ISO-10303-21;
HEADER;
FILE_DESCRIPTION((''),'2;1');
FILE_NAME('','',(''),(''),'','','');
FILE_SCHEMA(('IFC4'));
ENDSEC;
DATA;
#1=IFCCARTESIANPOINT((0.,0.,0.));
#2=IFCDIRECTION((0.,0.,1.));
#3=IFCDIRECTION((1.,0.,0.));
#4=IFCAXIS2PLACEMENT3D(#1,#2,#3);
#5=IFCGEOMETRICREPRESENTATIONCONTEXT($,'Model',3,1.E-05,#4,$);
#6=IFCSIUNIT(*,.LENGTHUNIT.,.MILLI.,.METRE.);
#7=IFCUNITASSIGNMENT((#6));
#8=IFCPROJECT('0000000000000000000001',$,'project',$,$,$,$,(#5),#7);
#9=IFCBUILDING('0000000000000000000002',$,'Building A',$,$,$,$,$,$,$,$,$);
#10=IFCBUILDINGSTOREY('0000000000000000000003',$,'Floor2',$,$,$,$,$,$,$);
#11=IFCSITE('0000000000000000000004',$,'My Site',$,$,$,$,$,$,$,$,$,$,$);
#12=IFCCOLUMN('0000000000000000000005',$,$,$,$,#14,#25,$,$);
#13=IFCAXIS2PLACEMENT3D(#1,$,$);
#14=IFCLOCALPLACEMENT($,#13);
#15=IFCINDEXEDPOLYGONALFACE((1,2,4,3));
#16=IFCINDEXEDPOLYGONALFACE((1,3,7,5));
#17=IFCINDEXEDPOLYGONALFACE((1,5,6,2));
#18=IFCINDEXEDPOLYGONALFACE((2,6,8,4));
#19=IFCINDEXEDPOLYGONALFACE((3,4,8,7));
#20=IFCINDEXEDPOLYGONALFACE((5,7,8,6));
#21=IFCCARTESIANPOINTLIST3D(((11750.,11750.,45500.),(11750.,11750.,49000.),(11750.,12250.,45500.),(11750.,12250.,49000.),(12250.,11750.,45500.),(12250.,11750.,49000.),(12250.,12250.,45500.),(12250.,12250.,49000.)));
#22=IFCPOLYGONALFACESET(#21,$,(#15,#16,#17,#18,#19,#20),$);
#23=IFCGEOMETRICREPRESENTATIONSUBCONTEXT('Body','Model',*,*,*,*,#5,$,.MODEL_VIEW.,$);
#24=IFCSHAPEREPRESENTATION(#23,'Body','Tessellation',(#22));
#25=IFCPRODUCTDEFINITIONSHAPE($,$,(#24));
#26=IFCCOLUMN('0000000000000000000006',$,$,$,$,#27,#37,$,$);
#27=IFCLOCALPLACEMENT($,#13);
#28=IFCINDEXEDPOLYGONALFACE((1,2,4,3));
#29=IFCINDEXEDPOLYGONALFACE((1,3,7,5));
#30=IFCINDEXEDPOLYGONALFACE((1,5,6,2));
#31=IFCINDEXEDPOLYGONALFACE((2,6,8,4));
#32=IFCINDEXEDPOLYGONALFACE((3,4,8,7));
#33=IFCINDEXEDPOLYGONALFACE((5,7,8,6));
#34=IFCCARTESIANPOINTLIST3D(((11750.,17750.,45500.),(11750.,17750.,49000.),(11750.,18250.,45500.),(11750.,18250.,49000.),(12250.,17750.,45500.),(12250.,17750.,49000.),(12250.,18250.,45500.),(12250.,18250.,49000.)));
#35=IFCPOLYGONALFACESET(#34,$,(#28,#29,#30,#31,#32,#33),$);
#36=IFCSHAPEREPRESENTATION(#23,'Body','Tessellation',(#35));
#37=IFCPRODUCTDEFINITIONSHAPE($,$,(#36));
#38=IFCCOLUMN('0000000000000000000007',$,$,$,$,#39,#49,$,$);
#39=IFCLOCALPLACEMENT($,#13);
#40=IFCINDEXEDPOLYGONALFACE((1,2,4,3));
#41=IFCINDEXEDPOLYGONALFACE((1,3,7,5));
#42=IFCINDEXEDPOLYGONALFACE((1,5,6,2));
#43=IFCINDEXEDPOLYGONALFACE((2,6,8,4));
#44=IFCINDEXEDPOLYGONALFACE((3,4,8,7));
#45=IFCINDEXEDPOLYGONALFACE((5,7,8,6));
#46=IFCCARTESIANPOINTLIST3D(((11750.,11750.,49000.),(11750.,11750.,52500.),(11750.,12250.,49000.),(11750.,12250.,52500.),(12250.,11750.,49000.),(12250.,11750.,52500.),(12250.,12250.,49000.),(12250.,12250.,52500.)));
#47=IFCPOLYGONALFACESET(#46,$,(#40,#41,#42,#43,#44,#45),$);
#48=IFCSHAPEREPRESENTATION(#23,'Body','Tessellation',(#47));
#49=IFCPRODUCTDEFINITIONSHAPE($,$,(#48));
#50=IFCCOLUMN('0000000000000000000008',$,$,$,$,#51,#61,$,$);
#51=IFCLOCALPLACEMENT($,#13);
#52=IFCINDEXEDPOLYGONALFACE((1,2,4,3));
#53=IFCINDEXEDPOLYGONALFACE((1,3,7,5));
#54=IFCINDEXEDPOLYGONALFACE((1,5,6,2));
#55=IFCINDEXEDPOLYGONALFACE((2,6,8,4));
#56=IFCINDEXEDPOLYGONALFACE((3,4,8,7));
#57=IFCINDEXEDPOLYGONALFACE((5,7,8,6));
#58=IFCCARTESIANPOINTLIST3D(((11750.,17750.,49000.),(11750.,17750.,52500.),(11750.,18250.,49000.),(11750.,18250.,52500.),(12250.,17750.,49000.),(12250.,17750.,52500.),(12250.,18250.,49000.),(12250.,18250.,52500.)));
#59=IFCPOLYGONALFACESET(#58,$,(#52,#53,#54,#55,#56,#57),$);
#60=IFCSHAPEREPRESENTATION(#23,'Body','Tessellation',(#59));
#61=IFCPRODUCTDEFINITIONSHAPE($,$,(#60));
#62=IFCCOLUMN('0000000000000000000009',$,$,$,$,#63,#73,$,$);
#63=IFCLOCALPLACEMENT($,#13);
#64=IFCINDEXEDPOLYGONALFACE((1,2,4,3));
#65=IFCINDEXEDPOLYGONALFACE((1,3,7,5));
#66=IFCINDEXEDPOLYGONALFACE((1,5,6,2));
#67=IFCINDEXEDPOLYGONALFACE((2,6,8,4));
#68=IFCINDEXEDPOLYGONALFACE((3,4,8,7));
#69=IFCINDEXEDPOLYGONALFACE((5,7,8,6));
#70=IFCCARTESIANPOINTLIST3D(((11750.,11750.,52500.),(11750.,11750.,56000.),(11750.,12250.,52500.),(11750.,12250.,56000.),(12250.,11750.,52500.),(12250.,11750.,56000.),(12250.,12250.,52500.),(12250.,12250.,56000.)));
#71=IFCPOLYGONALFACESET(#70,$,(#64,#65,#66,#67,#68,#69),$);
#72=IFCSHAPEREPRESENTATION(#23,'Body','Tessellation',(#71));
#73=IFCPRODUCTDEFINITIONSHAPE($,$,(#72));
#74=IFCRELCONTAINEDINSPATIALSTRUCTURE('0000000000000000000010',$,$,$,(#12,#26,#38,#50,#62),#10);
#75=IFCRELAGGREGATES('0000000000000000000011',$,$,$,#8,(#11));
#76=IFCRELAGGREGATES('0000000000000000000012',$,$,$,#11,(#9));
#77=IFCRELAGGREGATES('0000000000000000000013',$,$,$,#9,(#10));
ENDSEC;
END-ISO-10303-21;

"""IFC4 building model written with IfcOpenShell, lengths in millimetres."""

from ifc_helpers import new_model, si_unit, frame, origin_with_axes, place, context, subcontext, project, spatial, line, indexed_curve, outline, extrude, element, save


model = new_model("IFC4")

# Units and contexts
model_context = context("Model", 3, precision=1e-05, world=origin_with_axes())
body_context = subcontext(model_context, "Body", "Model", "MODEL_VIEW")
ifc_project = project(units=[si_unit("LENGTHUNIT", "METRE", prefix="MILLI")], contexts=[model_context])

# Site, building, storey
site = spatial("IfcSite", under=ifc_project, Name="My Site")
building = spatial("IfcBuilding", under=site, Name="Building A")
storey = spatial("IfcBuildingStorey", under=building, Name="Floor2")

# Columns
for number, where, z_axis, x_axis in (
    (1, (12000.0, 12000.0, 45500.0), (0.0, 0.0, 1.0), (1.0, 0.0, 0.0)),
    (2, (12000.0, 18000.0, 45500.0), (0.0, 0.0, 1.0), (1.0, 0.0, 0.0)),
    (3, (12000.0, 12000.0, 49000.0), (0.0, 0.0, 1.0), (1.0, 0.0, 0.0)),
    (4, (12000.0, 18000.0, 49000.0), (0.0, 0.0, 1.0), (1.0, 0.0, 0.0)),
    (5, (12000.0, 12000.0, 52500.0), (0.0, 0.0, 1.0), (1.0, 0.0, 0.0)),
):
    element("IfcColumn", number, at=place(None, frame(where, z_axis=z_axis, x_axis=x_axis)), inside=storey, context=body_context, shape_type="SweptSolid", body=[
        extrude(outline(indexed_curve([(-250.0, -250.0), (250.0, -250.0), (250.0, 250.0), (-250.0, 250.0)], segments=[line(1, 2, 3, 4, 1)])), origin_with_axes(), (0.0, 0.0, 1.0), 3500.0),
    ])

save(model, "model.ifc")
